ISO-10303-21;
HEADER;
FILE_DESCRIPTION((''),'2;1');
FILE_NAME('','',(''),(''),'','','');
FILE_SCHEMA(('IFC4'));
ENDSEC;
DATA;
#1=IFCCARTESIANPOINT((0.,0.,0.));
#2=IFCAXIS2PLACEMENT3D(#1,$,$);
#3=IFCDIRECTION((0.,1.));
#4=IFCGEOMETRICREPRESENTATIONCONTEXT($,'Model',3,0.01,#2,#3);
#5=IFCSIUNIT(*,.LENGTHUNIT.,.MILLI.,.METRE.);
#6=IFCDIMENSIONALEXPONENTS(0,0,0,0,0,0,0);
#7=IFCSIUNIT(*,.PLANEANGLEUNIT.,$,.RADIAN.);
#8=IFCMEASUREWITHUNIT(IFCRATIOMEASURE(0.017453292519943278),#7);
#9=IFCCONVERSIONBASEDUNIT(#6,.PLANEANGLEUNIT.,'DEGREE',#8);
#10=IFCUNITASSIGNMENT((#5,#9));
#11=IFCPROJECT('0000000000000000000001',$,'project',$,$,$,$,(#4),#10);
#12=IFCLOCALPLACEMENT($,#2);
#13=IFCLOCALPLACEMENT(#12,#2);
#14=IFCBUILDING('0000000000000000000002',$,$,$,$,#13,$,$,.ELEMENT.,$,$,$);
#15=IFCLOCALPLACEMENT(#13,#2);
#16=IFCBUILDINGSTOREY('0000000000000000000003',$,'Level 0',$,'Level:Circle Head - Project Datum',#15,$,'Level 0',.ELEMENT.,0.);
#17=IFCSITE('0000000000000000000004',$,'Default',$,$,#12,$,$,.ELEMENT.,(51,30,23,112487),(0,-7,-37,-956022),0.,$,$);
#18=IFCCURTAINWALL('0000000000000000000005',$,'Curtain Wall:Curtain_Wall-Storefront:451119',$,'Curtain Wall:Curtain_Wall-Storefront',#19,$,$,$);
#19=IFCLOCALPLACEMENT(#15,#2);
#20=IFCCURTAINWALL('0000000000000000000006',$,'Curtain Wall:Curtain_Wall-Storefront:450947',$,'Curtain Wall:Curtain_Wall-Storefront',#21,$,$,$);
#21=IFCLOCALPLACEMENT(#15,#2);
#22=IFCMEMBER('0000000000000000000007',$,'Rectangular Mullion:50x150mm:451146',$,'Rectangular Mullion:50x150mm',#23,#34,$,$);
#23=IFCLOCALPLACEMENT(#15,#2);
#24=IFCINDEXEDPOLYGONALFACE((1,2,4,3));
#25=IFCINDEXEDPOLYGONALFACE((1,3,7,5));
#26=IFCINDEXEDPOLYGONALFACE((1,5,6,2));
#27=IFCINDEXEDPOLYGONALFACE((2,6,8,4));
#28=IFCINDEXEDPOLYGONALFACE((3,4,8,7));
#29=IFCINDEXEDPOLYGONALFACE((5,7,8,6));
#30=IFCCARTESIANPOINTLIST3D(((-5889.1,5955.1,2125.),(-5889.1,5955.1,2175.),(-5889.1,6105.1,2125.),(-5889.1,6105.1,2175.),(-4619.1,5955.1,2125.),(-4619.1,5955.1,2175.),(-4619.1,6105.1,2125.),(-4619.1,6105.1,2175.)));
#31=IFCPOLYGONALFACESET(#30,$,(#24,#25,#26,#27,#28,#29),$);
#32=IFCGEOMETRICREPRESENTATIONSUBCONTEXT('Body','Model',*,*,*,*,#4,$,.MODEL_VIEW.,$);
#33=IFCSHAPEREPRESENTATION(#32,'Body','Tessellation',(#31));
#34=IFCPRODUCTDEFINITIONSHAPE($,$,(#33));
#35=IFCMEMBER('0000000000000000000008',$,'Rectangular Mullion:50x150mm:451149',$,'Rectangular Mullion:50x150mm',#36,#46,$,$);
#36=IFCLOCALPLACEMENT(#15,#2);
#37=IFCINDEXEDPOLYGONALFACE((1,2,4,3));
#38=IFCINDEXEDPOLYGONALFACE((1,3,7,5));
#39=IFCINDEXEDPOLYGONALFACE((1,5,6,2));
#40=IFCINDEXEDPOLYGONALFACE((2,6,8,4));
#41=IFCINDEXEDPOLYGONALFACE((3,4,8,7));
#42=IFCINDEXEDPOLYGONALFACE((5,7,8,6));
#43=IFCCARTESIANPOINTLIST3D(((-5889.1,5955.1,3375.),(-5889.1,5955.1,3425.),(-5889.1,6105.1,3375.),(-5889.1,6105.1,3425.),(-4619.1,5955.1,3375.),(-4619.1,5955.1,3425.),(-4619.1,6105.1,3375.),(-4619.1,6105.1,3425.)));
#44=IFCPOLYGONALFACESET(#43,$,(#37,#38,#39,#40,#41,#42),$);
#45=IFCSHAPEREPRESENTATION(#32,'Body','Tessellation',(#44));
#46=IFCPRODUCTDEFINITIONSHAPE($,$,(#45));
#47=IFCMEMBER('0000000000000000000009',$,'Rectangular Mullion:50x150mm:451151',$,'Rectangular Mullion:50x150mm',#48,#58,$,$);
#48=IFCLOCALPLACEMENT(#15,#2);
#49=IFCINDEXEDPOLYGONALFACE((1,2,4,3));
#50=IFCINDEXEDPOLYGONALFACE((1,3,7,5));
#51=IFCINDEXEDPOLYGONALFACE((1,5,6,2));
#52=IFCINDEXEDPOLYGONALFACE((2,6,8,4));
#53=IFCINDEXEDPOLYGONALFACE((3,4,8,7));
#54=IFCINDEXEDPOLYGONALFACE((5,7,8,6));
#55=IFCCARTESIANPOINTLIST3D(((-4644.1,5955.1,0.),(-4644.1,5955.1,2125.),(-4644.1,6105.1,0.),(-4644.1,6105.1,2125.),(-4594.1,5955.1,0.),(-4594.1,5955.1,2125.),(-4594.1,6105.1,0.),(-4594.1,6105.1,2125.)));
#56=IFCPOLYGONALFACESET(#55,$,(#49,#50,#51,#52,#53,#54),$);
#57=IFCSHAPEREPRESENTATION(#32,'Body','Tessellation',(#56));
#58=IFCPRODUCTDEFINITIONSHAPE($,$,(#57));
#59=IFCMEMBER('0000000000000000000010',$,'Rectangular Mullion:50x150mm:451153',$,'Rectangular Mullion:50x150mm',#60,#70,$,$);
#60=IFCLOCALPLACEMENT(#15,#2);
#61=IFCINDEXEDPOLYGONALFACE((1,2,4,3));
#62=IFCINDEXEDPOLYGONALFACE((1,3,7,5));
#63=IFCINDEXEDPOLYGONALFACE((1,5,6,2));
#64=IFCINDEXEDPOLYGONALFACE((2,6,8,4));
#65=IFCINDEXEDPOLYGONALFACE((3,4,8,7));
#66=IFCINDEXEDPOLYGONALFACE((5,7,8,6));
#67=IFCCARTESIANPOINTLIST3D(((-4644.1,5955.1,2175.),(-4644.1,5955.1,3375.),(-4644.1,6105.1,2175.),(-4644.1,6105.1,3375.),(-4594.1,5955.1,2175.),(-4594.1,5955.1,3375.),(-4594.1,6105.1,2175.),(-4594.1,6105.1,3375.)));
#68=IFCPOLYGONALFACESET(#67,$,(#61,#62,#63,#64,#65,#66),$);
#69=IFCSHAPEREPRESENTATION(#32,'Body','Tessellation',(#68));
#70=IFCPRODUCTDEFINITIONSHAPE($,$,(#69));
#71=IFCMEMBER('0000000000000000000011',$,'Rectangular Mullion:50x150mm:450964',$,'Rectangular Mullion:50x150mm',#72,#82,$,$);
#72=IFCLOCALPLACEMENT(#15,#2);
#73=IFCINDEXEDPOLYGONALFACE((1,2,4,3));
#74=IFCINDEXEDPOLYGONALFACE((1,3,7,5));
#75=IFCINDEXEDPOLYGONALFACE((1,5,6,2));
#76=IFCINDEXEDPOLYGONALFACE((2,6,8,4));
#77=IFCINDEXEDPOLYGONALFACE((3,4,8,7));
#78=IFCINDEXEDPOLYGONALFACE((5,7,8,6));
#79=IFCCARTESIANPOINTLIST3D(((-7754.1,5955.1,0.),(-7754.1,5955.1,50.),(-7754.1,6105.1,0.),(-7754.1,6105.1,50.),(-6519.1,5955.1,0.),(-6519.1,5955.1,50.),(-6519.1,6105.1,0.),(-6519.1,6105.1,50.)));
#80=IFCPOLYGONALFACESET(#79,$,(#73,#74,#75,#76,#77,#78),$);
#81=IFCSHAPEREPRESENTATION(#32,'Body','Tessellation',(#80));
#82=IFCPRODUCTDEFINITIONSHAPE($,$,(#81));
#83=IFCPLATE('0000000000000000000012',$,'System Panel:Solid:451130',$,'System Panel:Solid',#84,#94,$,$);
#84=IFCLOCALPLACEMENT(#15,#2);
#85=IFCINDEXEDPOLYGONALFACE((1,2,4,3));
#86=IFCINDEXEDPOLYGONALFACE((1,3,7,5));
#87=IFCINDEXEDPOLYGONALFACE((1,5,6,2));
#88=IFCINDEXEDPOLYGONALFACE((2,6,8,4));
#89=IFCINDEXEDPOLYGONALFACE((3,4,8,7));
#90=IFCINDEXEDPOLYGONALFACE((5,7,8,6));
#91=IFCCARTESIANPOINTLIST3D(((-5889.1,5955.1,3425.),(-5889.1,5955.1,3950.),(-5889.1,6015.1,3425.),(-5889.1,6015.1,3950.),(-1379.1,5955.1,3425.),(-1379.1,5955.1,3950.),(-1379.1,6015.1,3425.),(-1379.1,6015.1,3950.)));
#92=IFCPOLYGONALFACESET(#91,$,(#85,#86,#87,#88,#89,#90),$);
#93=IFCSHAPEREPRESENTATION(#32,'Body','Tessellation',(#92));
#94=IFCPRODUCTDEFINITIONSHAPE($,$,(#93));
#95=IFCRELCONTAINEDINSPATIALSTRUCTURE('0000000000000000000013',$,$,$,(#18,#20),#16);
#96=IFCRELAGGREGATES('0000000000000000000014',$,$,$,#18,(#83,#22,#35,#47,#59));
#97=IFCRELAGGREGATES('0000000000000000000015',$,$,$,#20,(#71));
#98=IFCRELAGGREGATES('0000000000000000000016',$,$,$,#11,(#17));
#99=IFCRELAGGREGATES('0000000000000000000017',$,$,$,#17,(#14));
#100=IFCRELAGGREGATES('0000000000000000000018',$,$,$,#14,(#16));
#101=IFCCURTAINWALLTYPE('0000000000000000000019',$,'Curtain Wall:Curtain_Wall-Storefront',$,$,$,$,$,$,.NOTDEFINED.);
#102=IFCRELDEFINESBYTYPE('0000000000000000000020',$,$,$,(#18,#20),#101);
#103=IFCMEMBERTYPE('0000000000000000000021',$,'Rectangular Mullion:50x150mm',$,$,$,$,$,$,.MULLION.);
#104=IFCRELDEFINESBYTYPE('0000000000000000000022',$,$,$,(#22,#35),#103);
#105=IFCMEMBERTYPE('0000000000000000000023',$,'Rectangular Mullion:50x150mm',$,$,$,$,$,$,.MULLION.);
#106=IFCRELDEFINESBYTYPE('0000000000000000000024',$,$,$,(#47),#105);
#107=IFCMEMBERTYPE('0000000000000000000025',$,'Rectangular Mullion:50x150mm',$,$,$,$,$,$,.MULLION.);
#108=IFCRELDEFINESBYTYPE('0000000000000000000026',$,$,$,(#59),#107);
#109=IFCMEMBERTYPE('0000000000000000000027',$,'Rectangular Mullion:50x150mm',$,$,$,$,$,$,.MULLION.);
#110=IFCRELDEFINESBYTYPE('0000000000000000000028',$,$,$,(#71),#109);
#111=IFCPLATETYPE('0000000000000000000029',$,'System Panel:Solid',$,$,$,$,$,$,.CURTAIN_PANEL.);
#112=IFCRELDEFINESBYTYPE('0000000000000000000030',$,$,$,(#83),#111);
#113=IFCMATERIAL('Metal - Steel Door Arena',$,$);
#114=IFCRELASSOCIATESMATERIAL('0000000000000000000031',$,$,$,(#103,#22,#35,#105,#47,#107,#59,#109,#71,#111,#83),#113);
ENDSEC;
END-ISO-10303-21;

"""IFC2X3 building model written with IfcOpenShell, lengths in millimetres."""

from ifc_helpers import new_model, entity, si_unit, converted_unit, direction, frame, frame_2d, origin, origin_2d_with_axis, place, context, subcontext, project, spatial, rectangle, extrude, source, transform, mapped, material, type_object, type_shapes, element, aggregate, save


model = new_model("IFC2X3")

# Units and contexts
model_context = context("Model", 3, precision=0.01, world=origin(), true_north=direction((0.0, 1.0)))
body_context = subcontext(model_context, "Body", "Model", "MODEL_VIEW")
ifc_project = project(units=[si_unit("LENGTHUNIT", "METRE", prefix="MILLI"), converted_unit("PLANEANGLEUNIT", "DEGREE", entity("IfcRatioMeasure", 0.017453292519943278), si_unit("PLANEANGLEUNIT", "RADIAN"), dimensions=[0, 0, 0, 0, 0, 0, 0])], contexts=[model_context])

# Site, building, storey
site_placement = place(None, origin())
site = spatial("IfcSite", under=ifc_project, at=site_placement, Name="Default", CompositionType="ELEMENT", RefLatitude=(51, 30, 23, 112487), RefLongitude=(0, -7, -37, -956022), RefElevation=0.0)
building_placement = place(site_placement, origin())
building = spatial("IfcBuilding", under=site, at=building_placement, CompositionType="ELEMENT")
storey_placement = place(building_placement, origin())
storey = spatial("IfcBuildingStorey", under=building, at=storey_placement, Name="Level 0", ObjectType="Level:Circle Head - Project Datum", LongName="Level 0", CompositionType="ELEMENT", Elevation=0.0)

# Curtain walls
curtain_wall_type = type_object("IfcCurtainWallType", Name="Curtain Wall:Curtain_Wall-Storefront", PredefinedType="NOTDEFINED")
curtain_wall_1_placement = place(storey_placement, origin())
curtain_wall_1 = element("IfcCurtainWall", 1, at=curtain_wall_1_placement, inside=storey, type_object=curtain_wall_type, Name="Curtain Wall:Curtain_Wall-Storefront:451119", ObjectType="Curtain Wall:Curtain_Wall-Storefront")
ifc_material_1 = material(Name="Metal - Steel Door Arena")
curtain_wall_2_placement = place(storey_placement, origin())
curtain_wall_2 = element("IfcCurtainWall", 2, at=curtain_wall_2_placement, inside=storey, type_object=curtain_wall_type, Name="Curtain Wall:Curtain_Wall-Storefront:450947", ObjectType="Curtain Wall:Curtain_Wall-Storefront")

# Members
member_type_1 = type_object("IfcMemberType", Name="Rectangular Mullion:50x150mm", PredefinedType="MULLION", material=ifc_material_1)
shared_shape_1 = source(origin(), body_context, "Body", "SweptSolid", [
    extrude(rectangle(XDim=150.0, YDim=50.0, at=origin_2d_with_axis()), frame((0.0, 0.0, -1270.0), z_axis=(0.0, 0.0, 1.0), x_axis=(0.0, -1.0, 0.0)), (0.0, 0.0, 1.0), 1270.0),
])
type_shapes(member_type_1, [shared_shape_1])
member_1_placement = place(curtain_wall_1_placement, frame((-5889.1, 6030.1, 2150.0), z_axis=(-1.0, 0.0, 0.0), x_axis=(0.0, 0.0, 1.0)))
member_1 = element("IfcMember", 3, at=member_1_placement, type_object=member_type_1, material=ifc_material_1, Name="Rectangular Mullion:50x150mm:451146", ObjectType="Rectangular Mullion:50x150mm", context=body_context, shape_type="MappedRepresentation", body=[
    mapped(shared_shape_1, transform((0.0, 0.0, 0.0), scale=1.0)),
])
member_2_placement = place(curtain_wall_1_placement, frame((-5889.1, 6030.1, 3400.0), z_axis=(-1.0, 0.0, 0.0), x_axis=(0.0, 0.0, 1.0)))
member_2 = element("IfcMember", 4, at=member_2_placement, type_object=member_type_1, material=ifc_material_1, Name="Rectangular Mullion:50x150mm:451149", ObjectType="Rectangular Mullion:50x150mm", context=body_context, shape_type="MappedRepresentation", body=[
    mapped(shared_shape_1, transform((0.0, 0.0, 0.0), scale=1.0)),
])
member_type_2 = type_object("IfcMemberType", Name="Rectangular Mullion:50x150mm", PredefinedType="MULLION", material=ifc_material_1)
shared_shape_2 = source(origin(), body_context, "Body", "SweptSolid", [
    extrude(rectangle(XDim=150.0, YDim=50.0, at=origin_2d_with_axis()), frame((0.0, 0.0, -2125.0), z_axis=(0.0, 0.0, 1.0), x_axis=(0.0, -1.0, 0.0)), (0.0, 0.0, 1.0), 2125.0),
])
type_shapes(member_type_2, [shared_shape_2])
member_3_placement = place(curtain_wall_1_placement, frame((-4619.1, 6030.1, 0.0), z_axis=(0.0, 0.0, -1.0), x_axis=(-1.0, 0.0, 0.0)))
member_3 = element("IfcMember", 5, at=member_3_placement, type_object=member_type_2, material=ifc_material_1, Name="Rectangular Mullion:50x150mm:451151", ObjectType="Rectangular Mullion:50x150mm", context=body_context, shape_type="MappedRepresentation", body=[
    mapped(shared_shape_2, transform((0.0, 0.0, 0.0), scale=1.0)),
])
member_type_3 = type_object("IfcMemberType", Name="Rectangular Mullion:50x150mm", PredefinedType="MULLION", material=ifc_material_1)
shared_shape_3 = source(origin(), body_context, "Body", "SweptSolid", [
    extrude(rectangle(XDim=150.0, YDim=50.0, at=origin_2d_with_axis()), frame((0.0, 0.0, -1200.0), z_axis=(0.0, 0.0, 1.0), x_axis=(0.0, -1.0, 0.0)), (0.0, 0.0, 1.0), 1200.0),
])
type_shapes(member_type_3, [shared_shape_3])
member_4_placement = place(curtain_wall_1_placement, frame((-4619.1, 6030.1, 2175.0), z_axis=(0.0, 0.0, -1.0), x_axis=(-1.0, 0.0, 0.0)))
member_4 = element("IfcMember", 6, at=member_4_placement, type_object=member_type_3, material=ifc_material_1, Name="Rectangular Mullion:50x150mm:451153", ObjectType="Rectangular Mullion:50x150mm", context=body_context, shape_type="MappedRepresentation", body=[
    mapped(shared_shape_3, transform((0.0, 0.0, 0.0), scale=1.0)),
])
member_type_4 = type_object("IfcMemberType", Name="Rectangular Mullion:50x150mm", PredefinedType="MULLION", material=ifc_material_1)
shared_shape_4 = source(origin(), body_context, "Body", "SweptSolid", [
    extrude(rectangle(XDim=150.0, YDim=50.0, at=origin_2d_with_axis()), frame((-25.0, 0.0, -1235.0), z_axis=(0.0, 0.0, 1.0), x_axis=(0.0, -1.0, 0.0)), (0.0, 0.0, 1.0), 1235.0),
])
type_shapes(member_type_4, [shared_shape_4])
member_5_placement = place(curtain_wall_2_placement, frame((-6519.1, 6030.1, 0.0), z_axis=(1.0, 0.0, 0.0), x_axis=(0.0, 0.0, -1.0)))
member_5 = element("IfcMember", 7, at=member_5_placement, type_object=member_type_4, material=ifc_material_1, Name="Rectangular Mullion:50x150mm:450964", ObjectType="Rectangular Mullion:50x150mm", context=body_context, shape_type="MappedRepresentation", body=[
    mapped(shared_shape_4, transform((0.0, 0.0, 0.0), scale=1.0)),
])

# Plate
plate_type_1 = type_object("IfcPlateType", Name="System Panel:Solid", PredefinedType="CURTAIN_PANEL", material=ifc_material_1)
shared_shape_5 = source(origin(), body_context, "Body", "SweptSolid", [
    extrude(rectangle(XDim=525.0, YDim=4510.0, at=frame_2d((0.0, 0.0), x_axis=(1.0, 0.0))), frame((0.0, 15.0, 262.5), z_axis=(0.0, 1.0, 0.0), x_axis=(0.0, 0.0, 1.0)), (0.0, 0.0, 1.0), 60.0),
])
type_shapes(plate_type_1, [shared_shape_5])
plate_1_placement = place(curtain_wall_1_placement, frame((-3634.1, 6030.1, 3425.0), z_axis=(0.0, 0.0, 1.0), x_axis=(-1.0, 0.0, 0.0)))
plate_1 = element("IfcPlate", 8, at=plate_1_placement, type_object=plate_type_1, material=ifc_material_1, Name="System Panel:Solid:451130", ObjectType="System Panel:Solid", context=body_context, shape_type="MappedRepresentation", body=[
    mapped(shared_shape_5, transform((0.0, 0.0, 0.0), scale=1.0)),
])
aggregate(curtain_wall_1, [plate_1, member_1, member_2, member_3, member_4])
aggregate(curtain_wall_2, [member_5])

save(model, "model.ifc")
